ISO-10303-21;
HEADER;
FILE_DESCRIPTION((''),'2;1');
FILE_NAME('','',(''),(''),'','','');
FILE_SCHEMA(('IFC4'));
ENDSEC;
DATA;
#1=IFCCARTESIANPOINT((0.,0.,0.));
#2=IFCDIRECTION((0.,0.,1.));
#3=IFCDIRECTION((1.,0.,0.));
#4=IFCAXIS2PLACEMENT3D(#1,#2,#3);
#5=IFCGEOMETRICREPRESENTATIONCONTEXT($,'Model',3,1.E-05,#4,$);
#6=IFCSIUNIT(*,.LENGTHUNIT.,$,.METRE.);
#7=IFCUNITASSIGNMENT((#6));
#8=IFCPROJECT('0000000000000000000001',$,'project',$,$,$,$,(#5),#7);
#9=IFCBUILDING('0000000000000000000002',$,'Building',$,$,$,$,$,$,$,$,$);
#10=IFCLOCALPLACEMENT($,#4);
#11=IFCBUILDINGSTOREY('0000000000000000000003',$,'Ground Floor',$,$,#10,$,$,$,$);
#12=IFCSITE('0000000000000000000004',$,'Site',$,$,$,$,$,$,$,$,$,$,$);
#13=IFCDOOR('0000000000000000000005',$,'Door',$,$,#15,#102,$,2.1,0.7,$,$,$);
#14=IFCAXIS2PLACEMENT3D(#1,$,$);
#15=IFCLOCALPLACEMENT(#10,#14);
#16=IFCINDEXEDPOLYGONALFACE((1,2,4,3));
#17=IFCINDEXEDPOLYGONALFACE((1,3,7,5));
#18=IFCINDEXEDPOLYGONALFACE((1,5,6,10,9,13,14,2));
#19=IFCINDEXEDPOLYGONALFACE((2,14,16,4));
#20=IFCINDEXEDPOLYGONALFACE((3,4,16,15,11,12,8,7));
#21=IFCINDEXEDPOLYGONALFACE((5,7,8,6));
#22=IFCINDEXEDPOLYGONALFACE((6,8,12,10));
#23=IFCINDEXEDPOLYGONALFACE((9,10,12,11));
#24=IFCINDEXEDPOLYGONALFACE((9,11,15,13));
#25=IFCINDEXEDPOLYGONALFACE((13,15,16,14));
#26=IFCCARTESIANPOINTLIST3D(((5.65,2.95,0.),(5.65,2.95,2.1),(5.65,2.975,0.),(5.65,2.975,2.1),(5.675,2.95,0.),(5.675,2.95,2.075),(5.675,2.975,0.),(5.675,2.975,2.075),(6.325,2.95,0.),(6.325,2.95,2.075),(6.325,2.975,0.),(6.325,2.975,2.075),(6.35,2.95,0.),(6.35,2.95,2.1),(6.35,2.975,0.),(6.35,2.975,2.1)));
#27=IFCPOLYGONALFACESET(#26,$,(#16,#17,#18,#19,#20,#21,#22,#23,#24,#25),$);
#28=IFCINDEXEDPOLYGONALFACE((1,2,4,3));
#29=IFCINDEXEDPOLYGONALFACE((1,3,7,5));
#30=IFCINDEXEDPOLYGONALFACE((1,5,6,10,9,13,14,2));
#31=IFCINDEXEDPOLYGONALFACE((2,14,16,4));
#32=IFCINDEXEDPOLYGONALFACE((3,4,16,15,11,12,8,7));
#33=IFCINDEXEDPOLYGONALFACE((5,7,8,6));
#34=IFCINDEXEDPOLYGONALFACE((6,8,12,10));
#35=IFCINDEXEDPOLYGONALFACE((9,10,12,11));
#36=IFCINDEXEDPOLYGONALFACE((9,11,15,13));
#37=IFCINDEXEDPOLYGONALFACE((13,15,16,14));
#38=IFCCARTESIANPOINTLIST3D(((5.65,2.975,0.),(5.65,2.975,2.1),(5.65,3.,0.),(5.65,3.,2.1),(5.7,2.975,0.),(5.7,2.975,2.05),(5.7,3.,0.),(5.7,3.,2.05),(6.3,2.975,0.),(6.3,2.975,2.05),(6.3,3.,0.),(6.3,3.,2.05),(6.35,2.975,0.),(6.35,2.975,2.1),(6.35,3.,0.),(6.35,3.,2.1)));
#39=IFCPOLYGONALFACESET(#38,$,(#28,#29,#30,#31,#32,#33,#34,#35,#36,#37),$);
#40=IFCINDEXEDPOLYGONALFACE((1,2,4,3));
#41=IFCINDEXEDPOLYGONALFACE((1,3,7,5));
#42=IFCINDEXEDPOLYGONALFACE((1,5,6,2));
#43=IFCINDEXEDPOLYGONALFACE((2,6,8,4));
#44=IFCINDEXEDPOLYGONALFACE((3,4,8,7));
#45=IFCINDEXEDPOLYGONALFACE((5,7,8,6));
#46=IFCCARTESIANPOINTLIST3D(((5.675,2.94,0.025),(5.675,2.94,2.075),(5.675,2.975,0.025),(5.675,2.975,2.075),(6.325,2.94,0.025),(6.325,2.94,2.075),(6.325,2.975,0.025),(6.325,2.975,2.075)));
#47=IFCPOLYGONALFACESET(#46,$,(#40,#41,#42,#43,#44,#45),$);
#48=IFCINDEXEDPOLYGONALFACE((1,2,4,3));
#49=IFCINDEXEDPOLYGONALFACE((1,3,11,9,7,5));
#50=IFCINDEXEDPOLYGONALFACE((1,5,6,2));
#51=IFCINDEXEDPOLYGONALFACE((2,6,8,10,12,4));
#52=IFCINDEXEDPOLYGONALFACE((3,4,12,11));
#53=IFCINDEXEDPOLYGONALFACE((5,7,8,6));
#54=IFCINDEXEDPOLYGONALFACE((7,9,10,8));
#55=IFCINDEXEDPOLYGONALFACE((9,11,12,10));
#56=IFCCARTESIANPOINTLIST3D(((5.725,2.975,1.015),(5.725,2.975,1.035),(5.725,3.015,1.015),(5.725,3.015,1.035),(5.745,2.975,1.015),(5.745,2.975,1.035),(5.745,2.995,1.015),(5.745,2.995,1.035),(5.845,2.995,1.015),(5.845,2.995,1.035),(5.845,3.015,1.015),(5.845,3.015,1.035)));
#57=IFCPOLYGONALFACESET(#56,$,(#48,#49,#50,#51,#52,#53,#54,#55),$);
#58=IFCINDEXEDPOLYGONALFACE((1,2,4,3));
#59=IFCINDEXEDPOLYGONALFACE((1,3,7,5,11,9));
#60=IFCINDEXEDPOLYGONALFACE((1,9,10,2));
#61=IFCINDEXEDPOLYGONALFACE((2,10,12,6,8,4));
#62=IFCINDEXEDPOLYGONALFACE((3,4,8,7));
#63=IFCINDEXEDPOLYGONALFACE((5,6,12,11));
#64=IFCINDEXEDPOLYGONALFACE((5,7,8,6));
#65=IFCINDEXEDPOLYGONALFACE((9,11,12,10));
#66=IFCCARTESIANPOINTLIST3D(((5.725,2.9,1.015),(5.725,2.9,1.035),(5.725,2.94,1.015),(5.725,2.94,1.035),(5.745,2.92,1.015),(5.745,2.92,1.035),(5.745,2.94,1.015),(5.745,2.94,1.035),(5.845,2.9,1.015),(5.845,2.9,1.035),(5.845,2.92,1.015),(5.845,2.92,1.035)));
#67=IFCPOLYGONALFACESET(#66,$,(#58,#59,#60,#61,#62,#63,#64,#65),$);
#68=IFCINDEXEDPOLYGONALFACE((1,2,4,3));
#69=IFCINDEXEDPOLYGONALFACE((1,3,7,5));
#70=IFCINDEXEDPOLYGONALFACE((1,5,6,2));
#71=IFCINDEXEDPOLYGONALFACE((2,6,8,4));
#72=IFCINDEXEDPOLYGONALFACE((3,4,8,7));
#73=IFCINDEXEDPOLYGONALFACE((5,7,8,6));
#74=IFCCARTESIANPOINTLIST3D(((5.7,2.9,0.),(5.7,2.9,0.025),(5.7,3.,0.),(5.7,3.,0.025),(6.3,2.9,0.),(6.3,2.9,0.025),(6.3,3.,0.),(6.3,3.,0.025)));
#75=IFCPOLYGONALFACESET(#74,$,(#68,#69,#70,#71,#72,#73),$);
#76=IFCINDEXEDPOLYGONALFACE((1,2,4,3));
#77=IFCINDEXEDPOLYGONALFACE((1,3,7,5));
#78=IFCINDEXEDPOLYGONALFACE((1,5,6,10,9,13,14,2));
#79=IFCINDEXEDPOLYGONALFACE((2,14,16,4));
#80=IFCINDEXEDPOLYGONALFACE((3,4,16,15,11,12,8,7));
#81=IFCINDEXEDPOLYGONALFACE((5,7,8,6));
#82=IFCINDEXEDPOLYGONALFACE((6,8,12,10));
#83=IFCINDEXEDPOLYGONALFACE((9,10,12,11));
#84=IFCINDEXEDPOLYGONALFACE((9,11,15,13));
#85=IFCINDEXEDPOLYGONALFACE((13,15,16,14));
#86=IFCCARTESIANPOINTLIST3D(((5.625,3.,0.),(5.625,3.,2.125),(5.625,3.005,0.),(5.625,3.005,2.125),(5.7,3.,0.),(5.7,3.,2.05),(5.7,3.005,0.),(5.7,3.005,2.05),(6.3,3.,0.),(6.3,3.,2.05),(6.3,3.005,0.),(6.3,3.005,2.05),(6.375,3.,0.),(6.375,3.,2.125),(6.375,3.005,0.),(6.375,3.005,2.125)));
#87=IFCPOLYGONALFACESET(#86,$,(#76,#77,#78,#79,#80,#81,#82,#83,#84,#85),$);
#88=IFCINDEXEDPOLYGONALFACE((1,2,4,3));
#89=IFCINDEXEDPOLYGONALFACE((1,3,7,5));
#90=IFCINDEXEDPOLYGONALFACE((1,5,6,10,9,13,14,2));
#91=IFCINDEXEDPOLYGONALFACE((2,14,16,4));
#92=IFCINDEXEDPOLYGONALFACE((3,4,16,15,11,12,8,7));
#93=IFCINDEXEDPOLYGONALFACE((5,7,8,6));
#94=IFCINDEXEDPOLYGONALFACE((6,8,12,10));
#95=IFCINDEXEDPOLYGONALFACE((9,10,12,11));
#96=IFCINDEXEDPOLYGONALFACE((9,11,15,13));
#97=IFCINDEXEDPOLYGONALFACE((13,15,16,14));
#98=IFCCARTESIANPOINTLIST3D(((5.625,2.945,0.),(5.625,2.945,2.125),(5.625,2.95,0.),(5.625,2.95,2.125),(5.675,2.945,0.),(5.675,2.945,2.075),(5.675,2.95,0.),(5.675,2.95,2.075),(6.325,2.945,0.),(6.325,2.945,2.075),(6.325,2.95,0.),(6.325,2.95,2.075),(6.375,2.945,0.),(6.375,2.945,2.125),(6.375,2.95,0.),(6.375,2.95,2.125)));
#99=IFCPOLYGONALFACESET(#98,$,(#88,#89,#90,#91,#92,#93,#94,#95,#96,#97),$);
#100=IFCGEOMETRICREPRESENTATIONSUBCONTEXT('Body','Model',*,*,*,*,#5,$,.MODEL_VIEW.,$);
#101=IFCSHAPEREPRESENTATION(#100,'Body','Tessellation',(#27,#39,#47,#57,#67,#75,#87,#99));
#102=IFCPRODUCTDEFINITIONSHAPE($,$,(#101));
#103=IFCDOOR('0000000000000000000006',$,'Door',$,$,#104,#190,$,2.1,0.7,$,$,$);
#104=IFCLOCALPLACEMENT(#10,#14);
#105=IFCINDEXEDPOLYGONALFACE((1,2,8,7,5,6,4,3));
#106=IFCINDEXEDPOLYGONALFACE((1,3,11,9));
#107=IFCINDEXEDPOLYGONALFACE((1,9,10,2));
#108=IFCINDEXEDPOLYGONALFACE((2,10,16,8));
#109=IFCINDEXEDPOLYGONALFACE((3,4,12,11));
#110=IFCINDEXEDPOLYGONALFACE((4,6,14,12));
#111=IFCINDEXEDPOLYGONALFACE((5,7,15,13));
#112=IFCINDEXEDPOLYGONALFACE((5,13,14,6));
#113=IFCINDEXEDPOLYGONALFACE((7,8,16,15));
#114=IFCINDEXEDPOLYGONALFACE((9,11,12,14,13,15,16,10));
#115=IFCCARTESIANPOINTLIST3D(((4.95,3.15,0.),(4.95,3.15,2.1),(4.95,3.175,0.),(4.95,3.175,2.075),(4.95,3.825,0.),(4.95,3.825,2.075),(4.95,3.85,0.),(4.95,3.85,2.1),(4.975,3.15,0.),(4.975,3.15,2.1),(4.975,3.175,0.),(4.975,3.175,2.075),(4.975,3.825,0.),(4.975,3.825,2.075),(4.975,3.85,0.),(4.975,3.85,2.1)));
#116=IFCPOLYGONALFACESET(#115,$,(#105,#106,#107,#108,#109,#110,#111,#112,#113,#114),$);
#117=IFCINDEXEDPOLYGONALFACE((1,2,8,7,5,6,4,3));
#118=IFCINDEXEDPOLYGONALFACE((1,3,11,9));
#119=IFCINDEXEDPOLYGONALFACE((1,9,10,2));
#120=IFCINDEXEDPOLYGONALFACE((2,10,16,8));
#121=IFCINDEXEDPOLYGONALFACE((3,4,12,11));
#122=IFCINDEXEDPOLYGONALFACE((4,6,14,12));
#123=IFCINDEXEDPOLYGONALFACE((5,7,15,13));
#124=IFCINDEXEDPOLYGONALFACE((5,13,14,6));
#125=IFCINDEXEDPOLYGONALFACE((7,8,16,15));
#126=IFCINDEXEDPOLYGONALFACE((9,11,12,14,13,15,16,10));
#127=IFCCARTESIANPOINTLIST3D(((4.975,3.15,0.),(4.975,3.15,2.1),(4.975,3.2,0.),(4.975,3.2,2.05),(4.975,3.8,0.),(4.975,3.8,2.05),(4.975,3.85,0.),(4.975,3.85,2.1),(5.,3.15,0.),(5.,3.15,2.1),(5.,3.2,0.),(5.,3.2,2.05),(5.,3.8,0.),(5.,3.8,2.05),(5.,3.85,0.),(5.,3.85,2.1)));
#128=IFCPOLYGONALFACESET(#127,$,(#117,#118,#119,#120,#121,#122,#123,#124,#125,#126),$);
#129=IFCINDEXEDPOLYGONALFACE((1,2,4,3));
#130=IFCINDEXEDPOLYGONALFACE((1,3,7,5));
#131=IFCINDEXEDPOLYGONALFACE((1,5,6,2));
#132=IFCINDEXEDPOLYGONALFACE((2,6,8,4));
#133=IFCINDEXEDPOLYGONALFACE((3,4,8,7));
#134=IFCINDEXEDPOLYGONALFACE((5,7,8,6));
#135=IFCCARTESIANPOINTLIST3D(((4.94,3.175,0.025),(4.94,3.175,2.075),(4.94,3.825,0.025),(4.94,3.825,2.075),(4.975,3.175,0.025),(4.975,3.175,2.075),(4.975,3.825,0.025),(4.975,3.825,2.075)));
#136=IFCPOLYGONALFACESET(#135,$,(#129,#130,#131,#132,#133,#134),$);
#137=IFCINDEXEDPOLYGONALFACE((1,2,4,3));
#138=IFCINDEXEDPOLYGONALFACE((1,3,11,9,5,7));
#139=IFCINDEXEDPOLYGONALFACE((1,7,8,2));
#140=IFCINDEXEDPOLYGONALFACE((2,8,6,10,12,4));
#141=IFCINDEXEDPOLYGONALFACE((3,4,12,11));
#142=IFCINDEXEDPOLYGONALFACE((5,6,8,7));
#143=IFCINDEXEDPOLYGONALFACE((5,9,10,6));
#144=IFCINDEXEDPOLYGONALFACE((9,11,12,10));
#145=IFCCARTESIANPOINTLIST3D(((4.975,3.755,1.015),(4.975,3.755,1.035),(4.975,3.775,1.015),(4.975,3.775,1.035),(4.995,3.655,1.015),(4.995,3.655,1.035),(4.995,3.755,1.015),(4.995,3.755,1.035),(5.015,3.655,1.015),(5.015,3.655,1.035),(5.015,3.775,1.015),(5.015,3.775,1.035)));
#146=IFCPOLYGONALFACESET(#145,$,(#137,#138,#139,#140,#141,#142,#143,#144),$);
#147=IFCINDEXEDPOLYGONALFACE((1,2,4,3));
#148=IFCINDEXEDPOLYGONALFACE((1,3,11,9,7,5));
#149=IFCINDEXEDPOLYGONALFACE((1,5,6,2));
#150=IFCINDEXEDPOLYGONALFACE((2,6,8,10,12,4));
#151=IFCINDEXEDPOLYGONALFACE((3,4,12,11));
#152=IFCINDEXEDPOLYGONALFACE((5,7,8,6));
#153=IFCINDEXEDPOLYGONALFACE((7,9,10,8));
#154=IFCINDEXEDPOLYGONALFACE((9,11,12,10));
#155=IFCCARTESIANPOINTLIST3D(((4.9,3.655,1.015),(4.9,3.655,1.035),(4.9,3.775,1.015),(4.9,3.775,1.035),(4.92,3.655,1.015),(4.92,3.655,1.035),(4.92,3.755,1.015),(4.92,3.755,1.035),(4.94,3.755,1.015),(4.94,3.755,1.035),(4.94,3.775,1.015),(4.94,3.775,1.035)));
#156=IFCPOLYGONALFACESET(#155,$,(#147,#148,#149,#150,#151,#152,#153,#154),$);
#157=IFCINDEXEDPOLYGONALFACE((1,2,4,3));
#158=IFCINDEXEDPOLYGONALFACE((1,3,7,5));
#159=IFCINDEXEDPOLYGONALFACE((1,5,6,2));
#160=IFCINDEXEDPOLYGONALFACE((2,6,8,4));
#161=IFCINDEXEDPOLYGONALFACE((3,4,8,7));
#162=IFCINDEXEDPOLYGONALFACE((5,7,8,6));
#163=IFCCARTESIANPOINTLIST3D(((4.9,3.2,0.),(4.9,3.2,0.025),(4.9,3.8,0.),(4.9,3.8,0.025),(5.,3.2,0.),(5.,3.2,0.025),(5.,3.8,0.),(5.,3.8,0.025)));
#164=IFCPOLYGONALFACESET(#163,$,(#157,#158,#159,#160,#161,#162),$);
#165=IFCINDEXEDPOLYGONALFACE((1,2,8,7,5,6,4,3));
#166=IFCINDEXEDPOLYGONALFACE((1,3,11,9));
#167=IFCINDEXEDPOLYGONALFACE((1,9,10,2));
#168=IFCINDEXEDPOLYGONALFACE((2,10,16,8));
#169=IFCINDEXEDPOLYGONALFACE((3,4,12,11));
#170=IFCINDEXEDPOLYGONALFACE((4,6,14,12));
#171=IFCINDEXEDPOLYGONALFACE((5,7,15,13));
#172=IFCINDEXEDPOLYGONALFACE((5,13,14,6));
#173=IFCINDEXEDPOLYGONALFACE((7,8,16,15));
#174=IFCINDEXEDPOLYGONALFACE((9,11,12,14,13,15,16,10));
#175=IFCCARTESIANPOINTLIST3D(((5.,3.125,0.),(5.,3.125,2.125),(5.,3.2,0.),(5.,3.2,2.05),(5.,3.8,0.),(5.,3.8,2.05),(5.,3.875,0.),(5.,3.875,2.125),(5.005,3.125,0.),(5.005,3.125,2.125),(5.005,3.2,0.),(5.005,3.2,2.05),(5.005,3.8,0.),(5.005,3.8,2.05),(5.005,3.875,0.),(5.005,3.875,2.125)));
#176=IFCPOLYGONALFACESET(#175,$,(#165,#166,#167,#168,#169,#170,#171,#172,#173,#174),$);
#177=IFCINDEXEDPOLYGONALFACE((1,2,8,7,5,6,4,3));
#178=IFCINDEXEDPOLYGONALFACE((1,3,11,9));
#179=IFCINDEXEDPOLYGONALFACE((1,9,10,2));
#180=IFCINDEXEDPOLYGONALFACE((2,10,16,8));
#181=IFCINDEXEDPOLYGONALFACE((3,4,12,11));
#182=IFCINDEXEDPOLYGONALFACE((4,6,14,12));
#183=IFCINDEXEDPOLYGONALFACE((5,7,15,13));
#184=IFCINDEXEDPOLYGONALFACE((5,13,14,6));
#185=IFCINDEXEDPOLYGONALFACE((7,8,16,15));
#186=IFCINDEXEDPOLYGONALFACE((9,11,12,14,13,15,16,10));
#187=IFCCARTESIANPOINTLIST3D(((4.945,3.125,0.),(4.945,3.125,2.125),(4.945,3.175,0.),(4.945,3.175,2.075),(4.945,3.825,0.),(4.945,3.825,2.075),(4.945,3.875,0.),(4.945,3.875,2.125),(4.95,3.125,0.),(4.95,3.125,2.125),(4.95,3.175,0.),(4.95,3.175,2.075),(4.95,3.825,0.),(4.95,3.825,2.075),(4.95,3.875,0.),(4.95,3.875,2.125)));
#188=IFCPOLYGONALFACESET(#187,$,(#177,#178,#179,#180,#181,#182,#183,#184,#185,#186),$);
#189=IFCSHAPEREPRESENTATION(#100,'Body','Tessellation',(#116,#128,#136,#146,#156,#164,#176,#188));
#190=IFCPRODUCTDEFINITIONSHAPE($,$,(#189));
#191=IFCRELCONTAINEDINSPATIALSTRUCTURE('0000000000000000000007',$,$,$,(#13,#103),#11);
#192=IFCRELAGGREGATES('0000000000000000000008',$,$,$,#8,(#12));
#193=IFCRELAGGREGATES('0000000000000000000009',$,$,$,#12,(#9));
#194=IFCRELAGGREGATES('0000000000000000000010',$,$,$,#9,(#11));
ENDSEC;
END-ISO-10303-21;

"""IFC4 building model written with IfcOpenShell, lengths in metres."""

from ifc_helpers import new_model, si_unit, frame, origin_with_axes, place, context, subcontext, project, spatial, line, indexed_curve, outline, extrude, element, save


model = new_model("IFC4")

# Units and contexts
model_context = context("Model", 3, precision=1e-05, world=origin_with_axes())
body_context = subcontext(model_context, "Body", "Model", "MODEL_VIEW")
ifc_project = project(units=[si_unit("LENGTHUNIT", "METRE")], contexts=[model_context])

# Site, building, storey
site = spatial("IfcSite", under=ifc_project, Name="Site")
building = spatial("IfcBuilding", under=site, Name="Building")
storey_placement = place(None, origin_with_axes())
storey = spatial("IfcBuildingStorey", under=building, at=storey_placement, Name="Ground Floor")

# Doors
door_1_placement = place(storey_placement, frame((6.35, 3.0, 0.0), z_axis=(0.0, 0.0, 1.0), x_axis=(-1.0, 0.0, 0.0)))
element("IfcDoor", 1, at=door_1_placement, inside=storey, Name="Door", OverallHeight=2.1, OverallWidth=0.7, context=body_context, shape_type="SweptSolid", body=[
    extrude(outline(indexed_curve([(0.0, 0.0), (0.0, 2.1), (0.7, 2.1), (0.7, 0.0), (0.675, 0.0), (0.675, 2.075), (0.025, 2.075), (0.025, 0.0)], segments=[line(1, 2, 3, 4, 5, 6, 7, 8, 1)])), frame((0.0, 0.025, 0.0), z_axis=(0.0, -1.0, 0.0), x_axis=(1.0, 0.0, 0.0)), (0.0, 0.0, -1.0), 0.025),
    extrude(outline(indexed_curve([(0.0, 0.0), (0.0, 2.1), (0.7, 2.1), (0.7, 0.0), (0.65, 0.0), (0.65, 2.05), (0.05, 2.05), (0.05, 0.0)], segments=[line(1, 2, 3, 4, 5, 6, 7, 8, 1)])), frame((0.0, 0.0, 0.0), z_axis=(0.0, -1.0, 0.0), x_axis=(1.0, 0.0, 0.0)), (0.0, 0.0, -1.0), 0.025),
    extrude(outline(indexed_curve([(0.0, 0.0), (0.65, 0.0), (0.65, 0.035), (0.0, 0.035)], segments=[line(1, 2, 3, 4, 1)])), frame((0.025, 0.025, 0.025), z_axis=(0.0, 0.0, 1.0), x_axis=(1.0, 0.0, 0.0)), (0.0, 0.0, 1.0), 2.05),
    extrude(outline(indexed_curve([(0.0, 0.0), (0.0, -0.04), (-0.12, -0.04), (-0.12, -0.02), (-0.02, -0.02), (-0.02, 0.0)], segments=[line(1, 2, 3, 4, 5, 6, 1)])), frame((0.625, 0.025, 1.015), z_axis=(0.0, 0.0, 1.0), x_axis=(1.0, 0.0, 0.0)), (0.0, 0.0, 1.0), 0.02),
    extrude(outline(indexed_curve([(0.0, 0.0), (0.0, 0.04), (-0.12, 0.04), (-0.12, 0.02), (-0.02, 0.02), (-0.02, 0.0)], segments=[line(1, 2, 3, 4, 5, 6, 1)])), frame((0.625, 0.06, 1.015), z_axis=(0.0, 0.0, 1.0), x_axis=(1.0, 0.0, 0.0)), (0.0, 0.0, 1.0), 0.02),
    extrude(outline(indexed_curve([(0.0, 0.0), (0.6, 0.0), (0.6, 0.1), (0.0, 0.1)], segments=[line(1, 2, 3, 4, 1)])), frame((0.05, 0.0, 0.0), z_axis=(0.0, 0.0, 1.0), x_axis=(1.0, 0.0, 0.0)), (0.0, 0.0, 1.0), 0.025),
    extrude(outline(indexed_curve([(0.0, 0.0), (0.0, 2.125), (0.75, 2.125), (0.75, 0.0), (0.675, 0.0), (0.675, 2.05), (0.075, 2.05), (0.075, 0.0)], segments=[line(1, 2, 3, 4, 5, 6, 7, 8, 1)])), frame((-0.025, -0.005, 0.0), z_axis=(0.0, -1.0, 0.0), x_axis=(1.0, 0.0, 0.0)), (0.0, 0.0, -1.0), 0.005),
    extrude(outline(indexed_curve([(0.0, 0.0), (0.0, 2.125), (0.75, 2.125), (0.75, 0.0), (0.7, 0.0), (0.7, 2.075), (0.05, 2.075), (0.05, 0.0)], segments=[line(1, 2, 3, 4, 5, 6, 7, 8, 1)])), frame((-0.025, 0.05, 0.0), z_axis=(0.0, -1.0, 0.0), x_axis=(1.0, 0.0, 0.0)), (0.0, 0.0, -1.0), 0.005),
])
door_2_placement = place(storey_placement, frame((5.0, 3.15, 0.0), z_axis=(0.0, 0.0, 1.0), x_axis=(0.0, 1.0, 0.0)))
element("IfcDoor", 2, at=door_2_placement, inside=storey, Name="Door", OverallHeight=2.1, OverallWidth=0.7, context=body_context, shape_type="SweptSolid", body=[
    extrude(outline(indexed_curve([(0.0, 0.0), (0.0, 2.1), (0.7, 2.1), (0.7, 0.0), (0.675, 0.0), (0.675, 2.075), (0.025, 2.075), (0.025, 0.0)], segments=[line(1, 2, 3, 4, 5, 6, 7, 8, 1)])), frame((0.0, 0.025, 0.0), z_axis=(0.0, -1.0, 0.0), x_axis=(1.0, 0.0, 0.0)), (0.0, 0.0, -1.0), 0.025),
    extrude(outline(indexed_curve([(0.0, 0.0), (0.0, 2.1), (0.7, 2.1), (0.7, 0.0), (0.65, 0.0), (0.65, 2.05), (0.05, 2.05), (0.05, 0.0)], segments=[line(1, 2, 3, 4, 5, 6, 7, 8, 1)])), frame((0.0, 0.0, 0.0), z_axis=(0.0, -1.0, 0.0), x_axis=(1.0, 0.0, 0.0)), (0.0, 0.0, -1.0), 0.025),
    extrude(outline(indexed_curve([(0.0, 0.0), (0.65, 0.0), (0.65, 0.035), (0.0, 0.035)], segments=[line(1, 2, 3, 4, 1)])), frame((0.025, 0.025, 0.025), z_axis=(0.0, 0.0, 1.0), x_axis=(1.0, 0.0, 0.0)), (0.0, 0.0, 1.0), 2.05),
    extrude(outline(indexed_curve([(0.0, 0.0), (0.0, -0.04), (-0.12, -0.04), (-0.12, -0.02), (-0.02, -0.02), (-0.02, 0.0)], segments=[line(1, 2, 3, 4, 5, 6, 1)])), frame((0.625, 0.025, 1.015), z_axis=(0.0, 0.0, 1.0), x_axis=(1.0, 0.0, 0.0)), (0.0, 0.0, 1.0), 0.02),
    extrude(outline(indexed_curve([(0.0, 0.0), (0.0, 0.04), (-0.12, 0.04), (-0.12, 0.02), (-0.02, 0.02), (-0.02, 0.0)], segments=[line(1, 2, 3, 4, 5, 6, 1)])), frame((0.625, 0.06, 1.015), z_axis=(0.0, 0.0, 1.0), x_axis=(1.0, 0.0, 0.0)), (0.0, 0.0, 1.0), 0.02),
    extrude(outline(indexed_curve([(0.0, 0.0), (0.6, 0.0), (0.6, 0.1), (0.0, 0.1)], segments=[line(1, 2, 3, 4, 1)])), frame((0.05, 0.0, 0.0), z_axis=(0.0, 0.0, 1.0), x_axis=(1.0, 0.0, 0.0)), (0.0, 0.0, 1.0), 0.025),
    extrude(outline(indexed_curve([(0.0, 0.0), (0.0, 2.125), (0.75, 2.125), (0.75, 0.0), (0.675, 0.0), (0.675, 2.05), (0.075, 2.05), (0.075, 0.0)], segments=[line(1, 2, 3, 4, 5, 6, 7, 8, 1)])), frame((-0.025, -0.005, 0.0), z_axis=(0.0, -1.0, 0.0), x_axis=(1.0, 0.0, 0.0)), (0.0, 0.0, -1.0), 0.005),
    extrude(outline(indexed_curve([(0.0, 0.0), (0.0, 2.125), (0.75, 2.125), (0.75, 0.0), (0.7, 0.0), (0.7, 2.075), (0.05, 2.075), (0.05, 0.0)], segments=[line(1, 2, 3, 4, 5, 6, 7, 8, 1)])), frame((-0.025, 0.05, 0.0), z_axis=(0.0, -1.0, 0.0), x_axis=(1.0, 0.0, 0.0)), (0.0, 0.0, -1.0), 0.005),
])

save(model, "model.ifc")
